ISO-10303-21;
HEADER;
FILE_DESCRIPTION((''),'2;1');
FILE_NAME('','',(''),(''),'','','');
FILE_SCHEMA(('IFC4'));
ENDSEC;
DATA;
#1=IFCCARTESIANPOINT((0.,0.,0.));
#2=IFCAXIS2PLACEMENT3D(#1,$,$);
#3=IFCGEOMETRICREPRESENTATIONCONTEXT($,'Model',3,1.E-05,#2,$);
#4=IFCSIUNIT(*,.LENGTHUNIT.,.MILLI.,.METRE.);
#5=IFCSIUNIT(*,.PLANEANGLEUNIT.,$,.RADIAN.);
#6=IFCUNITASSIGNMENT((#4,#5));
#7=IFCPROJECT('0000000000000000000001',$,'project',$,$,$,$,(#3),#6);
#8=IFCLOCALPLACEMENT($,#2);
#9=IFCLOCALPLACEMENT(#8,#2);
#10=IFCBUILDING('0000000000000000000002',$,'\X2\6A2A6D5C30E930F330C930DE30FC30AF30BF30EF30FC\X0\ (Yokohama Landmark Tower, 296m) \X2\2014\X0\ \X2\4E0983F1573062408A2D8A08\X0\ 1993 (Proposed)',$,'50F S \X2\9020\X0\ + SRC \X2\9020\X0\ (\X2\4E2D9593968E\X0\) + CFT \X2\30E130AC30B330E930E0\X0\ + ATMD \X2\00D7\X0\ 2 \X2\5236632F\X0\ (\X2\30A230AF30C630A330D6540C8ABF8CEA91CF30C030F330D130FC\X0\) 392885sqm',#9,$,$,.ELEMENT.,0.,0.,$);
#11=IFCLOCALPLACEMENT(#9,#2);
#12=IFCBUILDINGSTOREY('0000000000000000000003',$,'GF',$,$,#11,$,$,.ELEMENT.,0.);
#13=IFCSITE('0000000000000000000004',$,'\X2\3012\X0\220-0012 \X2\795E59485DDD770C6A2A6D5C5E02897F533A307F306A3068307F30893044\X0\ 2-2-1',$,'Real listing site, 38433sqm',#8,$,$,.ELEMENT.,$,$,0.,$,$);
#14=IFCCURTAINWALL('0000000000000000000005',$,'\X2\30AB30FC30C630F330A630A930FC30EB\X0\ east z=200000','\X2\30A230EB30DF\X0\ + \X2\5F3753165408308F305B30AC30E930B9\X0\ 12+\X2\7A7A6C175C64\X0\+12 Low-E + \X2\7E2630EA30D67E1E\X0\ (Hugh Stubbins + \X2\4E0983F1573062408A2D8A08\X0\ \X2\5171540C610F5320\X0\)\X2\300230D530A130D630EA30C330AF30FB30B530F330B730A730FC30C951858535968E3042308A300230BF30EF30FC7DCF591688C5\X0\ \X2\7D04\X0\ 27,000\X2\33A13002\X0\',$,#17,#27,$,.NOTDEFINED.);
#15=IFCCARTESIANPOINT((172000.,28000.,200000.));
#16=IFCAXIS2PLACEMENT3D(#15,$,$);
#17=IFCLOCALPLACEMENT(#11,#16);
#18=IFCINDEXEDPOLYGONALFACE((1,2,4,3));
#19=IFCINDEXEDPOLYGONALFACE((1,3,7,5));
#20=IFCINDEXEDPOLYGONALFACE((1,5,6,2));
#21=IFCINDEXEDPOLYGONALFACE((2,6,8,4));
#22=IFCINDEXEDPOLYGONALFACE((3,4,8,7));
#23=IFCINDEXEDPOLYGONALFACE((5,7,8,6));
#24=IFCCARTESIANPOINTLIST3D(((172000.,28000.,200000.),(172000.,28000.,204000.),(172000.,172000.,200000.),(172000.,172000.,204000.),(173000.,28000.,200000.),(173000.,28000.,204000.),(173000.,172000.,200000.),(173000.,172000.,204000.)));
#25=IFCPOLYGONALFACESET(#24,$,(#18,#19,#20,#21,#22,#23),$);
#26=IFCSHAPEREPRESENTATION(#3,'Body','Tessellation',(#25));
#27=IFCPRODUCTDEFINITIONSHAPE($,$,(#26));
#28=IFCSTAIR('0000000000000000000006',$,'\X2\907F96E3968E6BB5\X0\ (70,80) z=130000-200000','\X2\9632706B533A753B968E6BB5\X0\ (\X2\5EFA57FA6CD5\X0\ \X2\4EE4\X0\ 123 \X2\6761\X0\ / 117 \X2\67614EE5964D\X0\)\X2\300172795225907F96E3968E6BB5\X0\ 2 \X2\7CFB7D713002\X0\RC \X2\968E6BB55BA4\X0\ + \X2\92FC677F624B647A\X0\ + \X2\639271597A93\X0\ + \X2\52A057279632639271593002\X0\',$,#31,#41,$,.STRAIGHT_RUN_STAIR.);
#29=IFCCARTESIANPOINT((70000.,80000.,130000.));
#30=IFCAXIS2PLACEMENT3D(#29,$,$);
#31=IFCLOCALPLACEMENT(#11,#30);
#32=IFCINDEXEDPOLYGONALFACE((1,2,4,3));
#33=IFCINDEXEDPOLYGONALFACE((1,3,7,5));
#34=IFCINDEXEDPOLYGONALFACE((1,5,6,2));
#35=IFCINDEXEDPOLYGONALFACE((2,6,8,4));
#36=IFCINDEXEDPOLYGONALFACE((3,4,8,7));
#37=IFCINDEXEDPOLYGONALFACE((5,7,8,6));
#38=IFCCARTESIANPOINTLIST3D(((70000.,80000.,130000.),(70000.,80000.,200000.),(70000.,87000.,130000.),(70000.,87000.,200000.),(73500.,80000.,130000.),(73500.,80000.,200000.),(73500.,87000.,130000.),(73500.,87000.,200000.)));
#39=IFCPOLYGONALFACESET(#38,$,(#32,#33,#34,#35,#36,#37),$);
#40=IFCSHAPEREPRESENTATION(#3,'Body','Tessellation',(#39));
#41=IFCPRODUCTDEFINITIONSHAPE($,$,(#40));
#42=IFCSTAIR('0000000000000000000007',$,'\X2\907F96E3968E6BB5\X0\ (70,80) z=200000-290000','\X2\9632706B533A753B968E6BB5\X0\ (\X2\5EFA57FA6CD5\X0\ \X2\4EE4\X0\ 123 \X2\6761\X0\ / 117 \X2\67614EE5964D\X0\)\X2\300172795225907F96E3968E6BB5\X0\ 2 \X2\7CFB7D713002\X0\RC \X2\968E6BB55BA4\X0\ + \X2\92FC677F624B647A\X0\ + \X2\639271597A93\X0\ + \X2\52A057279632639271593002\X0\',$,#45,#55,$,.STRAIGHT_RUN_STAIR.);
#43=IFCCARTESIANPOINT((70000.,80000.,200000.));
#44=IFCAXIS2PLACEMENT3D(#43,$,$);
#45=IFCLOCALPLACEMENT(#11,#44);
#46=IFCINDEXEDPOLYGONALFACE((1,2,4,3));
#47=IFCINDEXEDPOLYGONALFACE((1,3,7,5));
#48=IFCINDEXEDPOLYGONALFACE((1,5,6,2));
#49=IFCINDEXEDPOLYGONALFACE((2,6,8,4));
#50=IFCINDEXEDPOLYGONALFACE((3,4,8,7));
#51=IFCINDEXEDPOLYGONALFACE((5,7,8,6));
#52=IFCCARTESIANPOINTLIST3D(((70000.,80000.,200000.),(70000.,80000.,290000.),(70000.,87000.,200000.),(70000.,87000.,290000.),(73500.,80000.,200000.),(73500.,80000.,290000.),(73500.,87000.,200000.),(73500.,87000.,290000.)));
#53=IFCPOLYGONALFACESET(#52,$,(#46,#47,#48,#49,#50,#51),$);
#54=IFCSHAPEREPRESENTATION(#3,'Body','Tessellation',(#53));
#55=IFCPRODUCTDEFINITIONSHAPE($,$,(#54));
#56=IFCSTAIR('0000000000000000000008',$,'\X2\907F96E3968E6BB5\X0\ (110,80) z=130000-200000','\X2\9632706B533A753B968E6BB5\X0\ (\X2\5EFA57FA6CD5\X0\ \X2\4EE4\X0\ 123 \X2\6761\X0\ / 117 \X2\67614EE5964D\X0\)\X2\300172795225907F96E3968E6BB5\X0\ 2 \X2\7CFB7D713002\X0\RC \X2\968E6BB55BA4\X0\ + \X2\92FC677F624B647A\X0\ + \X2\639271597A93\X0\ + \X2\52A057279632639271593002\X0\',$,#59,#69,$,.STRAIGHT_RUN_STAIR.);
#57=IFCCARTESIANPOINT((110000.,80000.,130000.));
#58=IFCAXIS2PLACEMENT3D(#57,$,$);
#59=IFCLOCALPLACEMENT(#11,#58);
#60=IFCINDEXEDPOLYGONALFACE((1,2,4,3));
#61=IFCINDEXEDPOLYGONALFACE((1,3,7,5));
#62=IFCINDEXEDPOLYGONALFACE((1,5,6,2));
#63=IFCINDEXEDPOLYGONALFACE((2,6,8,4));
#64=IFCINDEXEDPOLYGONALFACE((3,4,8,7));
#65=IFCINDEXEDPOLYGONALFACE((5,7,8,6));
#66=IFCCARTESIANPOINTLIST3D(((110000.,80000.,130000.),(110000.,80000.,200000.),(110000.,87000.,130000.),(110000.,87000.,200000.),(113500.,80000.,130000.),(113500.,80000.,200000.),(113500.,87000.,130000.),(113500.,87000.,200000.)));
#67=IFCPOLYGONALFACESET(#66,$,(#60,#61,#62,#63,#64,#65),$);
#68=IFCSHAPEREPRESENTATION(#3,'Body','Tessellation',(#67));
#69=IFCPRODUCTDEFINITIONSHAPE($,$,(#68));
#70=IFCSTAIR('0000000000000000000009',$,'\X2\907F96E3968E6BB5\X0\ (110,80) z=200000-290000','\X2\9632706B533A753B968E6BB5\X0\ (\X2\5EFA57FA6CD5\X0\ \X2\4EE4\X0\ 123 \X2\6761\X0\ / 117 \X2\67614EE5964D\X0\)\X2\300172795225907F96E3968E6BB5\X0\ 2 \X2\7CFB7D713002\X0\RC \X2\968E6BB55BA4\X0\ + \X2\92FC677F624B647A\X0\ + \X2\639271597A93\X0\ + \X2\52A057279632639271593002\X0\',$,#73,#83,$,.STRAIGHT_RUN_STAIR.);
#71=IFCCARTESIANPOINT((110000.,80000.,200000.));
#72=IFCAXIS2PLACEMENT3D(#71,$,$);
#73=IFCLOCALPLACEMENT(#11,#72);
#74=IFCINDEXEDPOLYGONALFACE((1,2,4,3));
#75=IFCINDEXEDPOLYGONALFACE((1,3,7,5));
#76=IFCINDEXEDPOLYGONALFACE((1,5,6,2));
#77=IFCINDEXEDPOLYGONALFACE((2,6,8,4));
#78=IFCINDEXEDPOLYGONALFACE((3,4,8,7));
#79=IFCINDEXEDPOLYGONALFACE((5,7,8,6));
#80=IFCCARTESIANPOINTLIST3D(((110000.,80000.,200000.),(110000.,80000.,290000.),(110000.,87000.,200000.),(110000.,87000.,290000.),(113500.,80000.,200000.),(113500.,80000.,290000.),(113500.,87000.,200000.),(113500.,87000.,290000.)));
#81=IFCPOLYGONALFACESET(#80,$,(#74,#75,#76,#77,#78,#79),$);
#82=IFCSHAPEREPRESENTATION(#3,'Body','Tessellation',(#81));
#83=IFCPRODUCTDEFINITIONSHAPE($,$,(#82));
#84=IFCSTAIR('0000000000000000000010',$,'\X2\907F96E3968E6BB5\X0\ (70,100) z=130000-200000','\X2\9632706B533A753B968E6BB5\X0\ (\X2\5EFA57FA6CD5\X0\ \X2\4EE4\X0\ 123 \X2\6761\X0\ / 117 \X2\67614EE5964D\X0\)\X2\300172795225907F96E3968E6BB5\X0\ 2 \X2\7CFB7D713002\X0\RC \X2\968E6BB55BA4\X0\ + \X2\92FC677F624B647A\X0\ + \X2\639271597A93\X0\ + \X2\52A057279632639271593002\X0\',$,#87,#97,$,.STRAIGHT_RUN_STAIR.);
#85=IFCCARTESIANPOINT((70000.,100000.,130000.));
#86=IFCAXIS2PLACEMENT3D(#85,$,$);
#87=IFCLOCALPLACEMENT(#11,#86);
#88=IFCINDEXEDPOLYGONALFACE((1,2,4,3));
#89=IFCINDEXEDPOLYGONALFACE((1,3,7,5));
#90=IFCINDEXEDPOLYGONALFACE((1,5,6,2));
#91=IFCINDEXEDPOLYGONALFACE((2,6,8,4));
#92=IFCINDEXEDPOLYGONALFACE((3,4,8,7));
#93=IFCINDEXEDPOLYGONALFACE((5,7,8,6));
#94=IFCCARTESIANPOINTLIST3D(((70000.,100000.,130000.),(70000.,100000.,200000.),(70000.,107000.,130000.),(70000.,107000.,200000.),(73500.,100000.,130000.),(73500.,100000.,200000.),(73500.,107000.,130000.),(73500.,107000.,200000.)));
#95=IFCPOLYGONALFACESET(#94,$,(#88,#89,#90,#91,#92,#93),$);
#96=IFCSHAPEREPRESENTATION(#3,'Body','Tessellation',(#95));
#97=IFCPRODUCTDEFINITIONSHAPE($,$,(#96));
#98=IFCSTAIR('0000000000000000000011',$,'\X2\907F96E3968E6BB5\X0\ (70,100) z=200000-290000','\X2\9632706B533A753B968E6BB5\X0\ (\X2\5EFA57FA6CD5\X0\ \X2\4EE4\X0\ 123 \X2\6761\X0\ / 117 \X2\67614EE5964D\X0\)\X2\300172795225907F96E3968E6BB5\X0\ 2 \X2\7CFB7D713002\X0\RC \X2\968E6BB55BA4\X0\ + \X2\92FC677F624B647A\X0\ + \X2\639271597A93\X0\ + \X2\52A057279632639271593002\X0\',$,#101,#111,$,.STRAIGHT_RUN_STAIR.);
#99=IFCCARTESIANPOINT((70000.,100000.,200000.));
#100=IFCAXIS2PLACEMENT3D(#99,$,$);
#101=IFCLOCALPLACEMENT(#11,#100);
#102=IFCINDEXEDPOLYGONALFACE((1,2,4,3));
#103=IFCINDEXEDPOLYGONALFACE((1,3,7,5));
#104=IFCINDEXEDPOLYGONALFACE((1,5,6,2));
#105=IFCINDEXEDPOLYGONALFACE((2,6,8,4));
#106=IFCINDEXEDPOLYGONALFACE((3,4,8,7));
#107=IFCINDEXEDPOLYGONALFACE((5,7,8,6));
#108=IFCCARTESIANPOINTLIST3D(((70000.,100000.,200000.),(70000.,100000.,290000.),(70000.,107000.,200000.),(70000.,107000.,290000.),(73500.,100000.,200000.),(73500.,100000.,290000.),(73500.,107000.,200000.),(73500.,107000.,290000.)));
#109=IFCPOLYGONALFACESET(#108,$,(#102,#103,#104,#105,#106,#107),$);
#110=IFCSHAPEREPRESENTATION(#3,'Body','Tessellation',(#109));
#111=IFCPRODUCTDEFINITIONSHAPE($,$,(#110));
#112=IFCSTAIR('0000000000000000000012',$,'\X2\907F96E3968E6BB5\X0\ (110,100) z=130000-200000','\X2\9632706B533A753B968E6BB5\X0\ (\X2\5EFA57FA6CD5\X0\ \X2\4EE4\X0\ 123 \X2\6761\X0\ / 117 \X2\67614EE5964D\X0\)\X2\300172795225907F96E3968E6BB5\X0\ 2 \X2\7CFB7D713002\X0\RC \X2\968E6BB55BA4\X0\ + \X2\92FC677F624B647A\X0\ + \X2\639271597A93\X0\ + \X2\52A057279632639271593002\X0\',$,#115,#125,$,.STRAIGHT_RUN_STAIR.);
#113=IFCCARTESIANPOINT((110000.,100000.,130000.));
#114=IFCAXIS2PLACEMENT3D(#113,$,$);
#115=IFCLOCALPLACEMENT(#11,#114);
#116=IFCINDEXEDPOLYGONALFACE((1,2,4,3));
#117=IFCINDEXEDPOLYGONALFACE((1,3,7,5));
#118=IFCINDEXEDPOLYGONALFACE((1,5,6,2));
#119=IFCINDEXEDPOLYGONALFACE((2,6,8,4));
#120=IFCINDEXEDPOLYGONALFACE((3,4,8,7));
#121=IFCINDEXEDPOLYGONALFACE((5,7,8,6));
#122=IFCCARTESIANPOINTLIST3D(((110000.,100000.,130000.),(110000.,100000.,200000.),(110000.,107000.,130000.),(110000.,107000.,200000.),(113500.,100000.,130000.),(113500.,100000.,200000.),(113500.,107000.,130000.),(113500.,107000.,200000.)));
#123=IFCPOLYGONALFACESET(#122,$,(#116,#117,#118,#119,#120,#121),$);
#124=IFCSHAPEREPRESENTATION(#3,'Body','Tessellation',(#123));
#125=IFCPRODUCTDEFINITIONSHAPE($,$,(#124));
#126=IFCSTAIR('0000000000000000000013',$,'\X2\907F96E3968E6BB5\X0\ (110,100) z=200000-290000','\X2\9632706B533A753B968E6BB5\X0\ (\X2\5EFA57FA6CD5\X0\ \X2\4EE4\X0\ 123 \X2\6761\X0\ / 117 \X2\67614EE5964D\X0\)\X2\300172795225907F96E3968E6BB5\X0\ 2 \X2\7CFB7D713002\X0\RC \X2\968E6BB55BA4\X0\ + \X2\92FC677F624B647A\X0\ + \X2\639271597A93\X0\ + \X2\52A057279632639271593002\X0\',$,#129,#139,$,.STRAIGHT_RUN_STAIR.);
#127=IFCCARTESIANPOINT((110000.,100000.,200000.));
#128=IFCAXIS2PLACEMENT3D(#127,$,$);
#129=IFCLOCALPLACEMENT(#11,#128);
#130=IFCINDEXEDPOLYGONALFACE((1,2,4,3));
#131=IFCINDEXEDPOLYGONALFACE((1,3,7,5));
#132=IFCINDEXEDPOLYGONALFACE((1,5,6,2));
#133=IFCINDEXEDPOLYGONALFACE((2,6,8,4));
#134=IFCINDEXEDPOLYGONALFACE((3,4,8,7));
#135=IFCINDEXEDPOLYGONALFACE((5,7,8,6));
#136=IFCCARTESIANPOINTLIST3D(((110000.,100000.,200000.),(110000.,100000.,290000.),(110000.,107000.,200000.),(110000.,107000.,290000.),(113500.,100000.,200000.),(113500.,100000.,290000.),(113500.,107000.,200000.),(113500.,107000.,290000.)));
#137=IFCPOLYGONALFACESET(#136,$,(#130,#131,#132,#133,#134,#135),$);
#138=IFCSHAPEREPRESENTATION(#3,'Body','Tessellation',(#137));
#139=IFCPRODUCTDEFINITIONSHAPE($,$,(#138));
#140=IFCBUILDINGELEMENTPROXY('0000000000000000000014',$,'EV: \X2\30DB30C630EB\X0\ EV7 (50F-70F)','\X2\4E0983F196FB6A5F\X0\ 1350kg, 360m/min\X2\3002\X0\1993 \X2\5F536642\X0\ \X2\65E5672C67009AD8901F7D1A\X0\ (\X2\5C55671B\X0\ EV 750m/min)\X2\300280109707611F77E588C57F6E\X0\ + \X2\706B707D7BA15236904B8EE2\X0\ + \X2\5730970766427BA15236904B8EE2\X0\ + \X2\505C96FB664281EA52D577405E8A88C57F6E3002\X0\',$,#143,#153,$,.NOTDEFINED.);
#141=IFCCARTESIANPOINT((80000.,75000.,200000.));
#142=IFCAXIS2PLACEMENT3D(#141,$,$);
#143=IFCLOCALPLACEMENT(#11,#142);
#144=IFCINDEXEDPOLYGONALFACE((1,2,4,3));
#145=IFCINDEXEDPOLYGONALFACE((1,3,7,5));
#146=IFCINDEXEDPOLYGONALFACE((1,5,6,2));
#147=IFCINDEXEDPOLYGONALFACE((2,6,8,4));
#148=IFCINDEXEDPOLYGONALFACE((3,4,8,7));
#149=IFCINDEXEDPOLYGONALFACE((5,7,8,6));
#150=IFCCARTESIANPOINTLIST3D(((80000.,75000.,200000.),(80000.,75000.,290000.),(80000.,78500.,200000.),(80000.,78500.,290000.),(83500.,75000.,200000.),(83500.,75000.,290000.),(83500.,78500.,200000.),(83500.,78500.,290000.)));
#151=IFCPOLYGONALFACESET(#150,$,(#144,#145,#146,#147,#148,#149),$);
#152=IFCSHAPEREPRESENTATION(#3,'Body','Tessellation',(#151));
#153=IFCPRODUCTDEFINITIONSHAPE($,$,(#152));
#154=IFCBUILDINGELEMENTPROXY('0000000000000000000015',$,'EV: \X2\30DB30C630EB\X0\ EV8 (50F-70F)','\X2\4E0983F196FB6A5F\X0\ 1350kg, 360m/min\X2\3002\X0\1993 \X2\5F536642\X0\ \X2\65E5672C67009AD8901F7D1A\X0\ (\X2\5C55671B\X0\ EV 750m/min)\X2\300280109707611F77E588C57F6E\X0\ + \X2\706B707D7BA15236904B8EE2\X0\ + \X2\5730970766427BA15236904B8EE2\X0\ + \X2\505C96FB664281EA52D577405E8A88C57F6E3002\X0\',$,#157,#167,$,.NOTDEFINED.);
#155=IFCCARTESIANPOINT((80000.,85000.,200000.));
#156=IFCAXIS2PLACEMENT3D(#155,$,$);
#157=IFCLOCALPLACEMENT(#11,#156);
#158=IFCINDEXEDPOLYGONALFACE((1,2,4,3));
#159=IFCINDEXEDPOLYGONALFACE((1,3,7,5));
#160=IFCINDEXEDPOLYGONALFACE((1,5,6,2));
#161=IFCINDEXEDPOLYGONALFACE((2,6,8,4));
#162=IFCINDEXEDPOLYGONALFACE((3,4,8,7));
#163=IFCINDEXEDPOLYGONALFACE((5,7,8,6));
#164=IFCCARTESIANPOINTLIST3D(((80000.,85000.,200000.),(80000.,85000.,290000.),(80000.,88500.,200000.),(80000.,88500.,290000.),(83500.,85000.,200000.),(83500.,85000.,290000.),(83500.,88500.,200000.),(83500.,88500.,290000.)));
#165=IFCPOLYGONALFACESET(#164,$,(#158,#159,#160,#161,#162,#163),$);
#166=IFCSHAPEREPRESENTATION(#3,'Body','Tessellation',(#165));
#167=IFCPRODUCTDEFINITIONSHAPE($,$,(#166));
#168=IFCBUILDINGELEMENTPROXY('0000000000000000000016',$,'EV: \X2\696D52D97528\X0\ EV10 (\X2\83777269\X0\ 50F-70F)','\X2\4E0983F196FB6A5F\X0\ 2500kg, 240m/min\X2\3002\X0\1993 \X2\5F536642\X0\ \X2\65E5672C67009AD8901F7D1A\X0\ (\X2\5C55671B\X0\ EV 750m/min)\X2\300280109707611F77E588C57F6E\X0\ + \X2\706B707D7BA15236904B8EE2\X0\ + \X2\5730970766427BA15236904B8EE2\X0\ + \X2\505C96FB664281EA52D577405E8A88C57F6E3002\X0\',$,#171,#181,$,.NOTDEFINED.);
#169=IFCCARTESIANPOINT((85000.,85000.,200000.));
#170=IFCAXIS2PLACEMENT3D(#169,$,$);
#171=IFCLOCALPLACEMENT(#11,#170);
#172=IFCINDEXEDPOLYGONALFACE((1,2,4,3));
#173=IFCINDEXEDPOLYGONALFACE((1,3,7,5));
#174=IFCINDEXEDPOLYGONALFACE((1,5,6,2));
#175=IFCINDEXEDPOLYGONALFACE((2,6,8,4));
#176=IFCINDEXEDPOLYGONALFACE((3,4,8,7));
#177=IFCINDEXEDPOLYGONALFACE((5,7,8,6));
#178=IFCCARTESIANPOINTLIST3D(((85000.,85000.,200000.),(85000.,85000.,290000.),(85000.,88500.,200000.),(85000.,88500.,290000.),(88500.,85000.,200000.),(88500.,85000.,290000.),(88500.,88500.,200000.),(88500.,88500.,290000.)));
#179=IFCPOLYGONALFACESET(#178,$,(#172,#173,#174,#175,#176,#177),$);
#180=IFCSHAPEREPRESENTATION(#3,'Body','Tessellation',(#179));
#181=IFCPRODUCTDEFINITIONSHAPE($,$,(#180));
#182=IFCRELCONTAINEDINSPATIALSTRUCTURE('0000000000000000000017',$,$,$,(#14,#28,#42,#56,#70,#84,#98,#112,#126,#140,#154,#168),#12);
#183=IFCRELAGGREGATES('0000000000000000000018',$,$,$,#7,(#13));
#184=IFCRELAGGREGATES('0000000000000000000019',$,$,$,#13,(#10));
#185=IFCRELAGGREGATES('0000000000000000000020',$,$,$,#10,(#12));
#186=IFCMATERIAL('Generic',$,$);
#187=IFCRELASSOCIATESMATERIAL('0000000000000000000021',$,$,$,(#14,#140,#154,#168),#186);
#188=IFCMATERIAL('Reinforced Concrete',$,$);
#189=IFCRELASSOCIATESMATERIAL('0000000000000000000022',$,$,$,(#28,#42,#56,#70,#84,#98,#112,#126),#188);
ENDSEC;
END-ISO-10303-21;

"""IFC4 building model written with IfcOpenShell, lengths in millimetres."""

from ifc_helpers import new_model, si_unit, frame, frame_2d, origin, place, context, project, spatial, rectangle, extrude, material, element, save


model = new_model("IFC4")

# Units and contexts
model_context = context("Model", 3, precision=1e-05, world=origin())
ifc_project = project(units=[si_unit("LENGTHUNIT", "METRE", prefix="MILLI"), si_unit("PLANEANGLEUNIT", "RADIAN")], contexts=[model_context])

# Site, building, storey
site_placement = place(None, origin())
site = spatial("IfcSite", under=ifc_project, at=site_placement, Name="〒220-0012 神奈川県横浜市西区みなとみらい 2-2-1", ObjectType="Real listing site, 38433sqm", CompositionType="ELEMENT", RefElevation=0.0)
building_placement = place(site_placement, origin())
building = spatial("IfcBuilding", under=site, at=building_placement, Name="横浜ランドマークタワー (Yokohama Landmark Tower, 296m) — 三菱地所設計 1993 (Proposed)", ObjectType="50F S 造 + SRC 造 (中間階) + CFT メガコラム + ATMD × 2 制振 (アクティブ同調質量ダンパー) 392885sqm", CompositionType="ELEMENT", ElevationOfRefHeight=0.0, ElevationOfTerrain=0.0)
storey_placement = place(building_placement, origin())
storey = spatial("IfcBuildingStorey", under=building, at=storey_placement, Name="GF", CompositionType="ELEMENT", Elevation=0.0)

# Shared definitions
ifc_material_1 = material(Name="Reinforced Concrete")

# Shared definitions
ifc_material_2 = material(Name="Generic")

# Curtain wall
curtain_wall_1_placement = place(storey_placement, frame((172000.0, 28000.0, 200000.0)))
element("IfcCurtainWall", 1, at=curtain_wall_1_placement, inside=storey, material=ifc_material_2, Name="カーテンウォール east z=200000", Description="アルミ + 強化合わせガラス 12+空気層+12 Low-E + 縦リブ縞 (Hugh Stubbins + 三菱地所設計 共同意匠)。ファブリック・サンシェード内蔵階あり。タワー総外装 約 27,000㎡。", PredefinedType="NOTDEFINED", context=model_context, shape_type="SweptSolid", body=[
    extrude(rectangle(XDim=1000.0, YDim=144000.0, at=frame_2d((500.0, 72000.0))), frame((172000.0, 28000.0, 200000.0)), (0.0, 0.0, 1.0), 4000.0),
])

# Stairs
stair_1_placement = place(storey_placement, frame((70000.0, 80000.0, 130000.0)))
element("IfcStair", 2, at=stair_1_placement, inside=storey, material=ifc_material_1, Name="避難階段 (70,80) z=130000-200000", Description="防火区画階段 (建基法 令 123 条 / 117 条以降)、特別避難階段 2 系統。RC 階段室 + 鋼板手摺 + 排煙窓 + 加圧防排煙。", PredefinedType="STRAIGHT_RUN_STAIR", context=model_context, shape_type="SweptSolid", body=[
    extrude(rectangle(XDim=3500.0, YDim=7000.0, at=frame_2d((1750.0, 3500.0))), frame((70000.0, 80000.0, 130000.0)), (0.0, 0.0, 1.0), 70000.0),
])
stair_2_placement = place(storey_placement, frame((70000.0, 80000.0, 200000.0)))
element("IfcStair", 3, at=stair_2_placement, inside=storey, material=ifc_material_1, Name="避難階段 (70,80) z=200000-290000", Description="防火区画階段 (建基法 令 123 条 / 117 条以降)、特別避難階段 2 系統。RC 階段室 + 鋼板手摺 + 排煙窓 + 加圧防排煙。", PredefinedType="STRAIGHT_RUN_STAIR", context=model_context, shape_type="SweptSolid", body=[
    extrude(rectangle(XDim=3500.0, YDim=7000.0, at=frame_2d((1750.0, 3500.0))), frame((70000.0, 80000.0, 200000.0)), (0.0, 0.0, 1.0), 90000.0),
])
stair_3_placement = place(storey_placement, frame((110000.0, 80000.0, 130000.0)))
element("IfcStair", 4, at=stair_3_placement, inside=storey, material=ifc_material_1, Name="避難階段 (110,80) z=130000-200000", Description="防火区画階段 (建基法 令 123 条 / 117 条以降)、特別避難階段 2 系統。RC 階段室 + 鋼板手摺 + 排煙窓 + 加圧防排煙。", PredefinedType="STRAIGHT_RUN_STAIR", context=model_context, shape_type="SweptSolid", body=[
    extrude(rectangle(XDim=3500.0, YDim=7000.0, at=frame_2d((1750.0, 3500.0))), frame((110000.0, 80000.0, 130000.0)), (0.0, 0.0, 1.0), 70000.0),
])
stair_4_placement = place(storey_placement, frame((110000.0, 80000.0, 200000.0)))
element("IfcStair", 5, at=stair_4_placement, inside=storey, material=ifc_material_1, Name="避難階段 (110,80) z=200000-290000", Description="防火区画階段 (建基法 令 123 条 / 117 条以降)、特別避難階段 2 系統。RC 階段室 + 鋼板手摺 + 排煙窓 + 加圧防排煙。", PredefinedType="STRAIGHT_RUN_STAIR", context=model_context, shape_type="SweptSolid", body=[
    extrude(rectangle(XDim=3500.0, YDim=7000.0, at=frame_2d((1750.0, 3500.0))), frame((110000.0, 80000.0, 200000.0)), (0.0, 0.0, 1.0), 90000.0),
])
stair_5_placement = place(storey_placement, frame((70000.0, 100000.0, 130000.0)))
element("IfcStair", 6, at=stair_5_placement, inside=storey, material=ifc_material_1, Name="避難階段 (70,100) z=130000-200000", Description="防火区画階段 (建基法 令 123 条 / 117 条以降)、特別避難階段 2 系統。RC 階段室 + 鋼板手摺 + 排煙窓 + 加圧防排煙。", PredefinedType="STRAIGHT_RUN_STAIR", context=model_context, shape_type="SweptSolid", body=[
    extrude(rectangle(XDim=3500.0, YDim=7000.0, at=frame_2d((1750.0, 3500.0))), frame((70000.0, 100000.0, 130000.0)), (0.0, 0.0, 1.0), 70000.0),
])
stair_6_placement = place(storey_placement, frame((70000.0, 100000.0, 200000.0)))
element("IfcStair", 7, at=stair_6_placement, inside=storey, material=ifc_material_1, Name="避難階段 (70,100) z=200000-290000", Description="防火区画階段 (建基法 令 123 条 / 117 条以降)、特別避難階段 2 系統。RC 階段室 + 鋼板手摺 + 排煙窓 + 加圧防排煙。", PredefinedType="STRAIGHT_RUN_STAIR", context=model_context, shape_type="SweptSolid", body=[
    extrude(rectangle(XDim=3500.0, YDim=7000.0, at=frame_2d((1750.0, 3500.0))), frame((70000.0, 100000.0, 200000.0)), (0.0, 0.0, 1.0), 90000.0),
])
stair_7_placement = place(storey_placement, frame((110000.0, 100000.0, 130000.0)))
element("IfcStair", 8, at=stair_7_placement, inside=storey, material=ifc_material_1, Name="避難階段 (110,100) z=130000-200000", Description="防火区画階段 (建基法 令 123 条 / 117 条以降)、特別避難階段 2 系統。RC 階段室 + 鋼板手摺 + 排煙窓 + 加圧防排煙。", PredefinedType="STRAIGHT_RUN_STAIR", context=model_context, shape_type="SweptSolid", body=[
    extrude(rectangle(XDim=3500.0, YDim=7000.0, at=frame_2d((1750.0, 3500.0))), frame((110000.0, 100000.0, 130000.0)), (0.0, 0.0, 1.0), 70000.0),
])
stair_8_placement = place(storey_placement, frame((110000.0, 100000.0, 200000.0)))
element("IfcStair", 9, at=stair_8_placement, inside=storey, material=ifc_material_1, Name="避難階段 (110,100) z=200000-290000", Description="防火区画階段 (建基法 令 123 条 / 117 条以降)、特別避難階段 2 系統。RC 階段室 + 鋼板手摺 + 排煙窓 + 加圧防排煙。", PredefinedType="STRAIGHT_RUN_STAIR", context=model_context, shape_type="SweptSolid", body=[
    extrude(rectangle(XDim=3500.0, YDim=7000.0, at=frame_2d((1750.0, 3500.0))), frame((110000.0, 100000.0, 200000.0)), (0.0, 0.0, 1.0), 90000.0),
])

# Building element proxies
proxy_1_placement = place(storey_placement, frame((80000.0, 75000.0, 200000.0)))
element("IfcBuildingElementProxy", 10, at=proxy_1_placement, inside=storey, material=ifc_material_2, Name="EV: ホテル EV7 (50F-70F)", Description="三菱電機 1350kg, 360m/min。1993 当時 日本最高速級 (展望 EV 750m/min)。耐震感知装置 + 火災管制運転 + 地震時管制運転 + 停電時自動着床装置。", PredefinedType="NOTDEFINED", context=model_context, shape_type="SweptSolid", body=[
    extrude(rectangle(XDim=3500.0, YDim=3500.0, at=frame_2d((1750.0, 1750.0))), frame((80000.0, 75000.0, 200000.0)), (0.0, 0.0, 1.0), 90000.0),
])
proxy_2_placement = place(storey_placement, frame((80000.0, 85000.0, 200000.0)))
element("IfcBuildingElementProxy", 11, at=proxy_2_placement, inside=storey, material=ifc_material_2, Name="EV: ホテル EV8 (50F-70F)", Description="三菱電機 1350kg, 360m/min。1993 当時 日本最高速級 (展望 EV 750m/min)。耐震感知装置 + 火災管制運転 + 地震時管制運転 + 停電時自動着床装置。", PredefinedType="NOTDEFINED", context=model_context, shape_type="SweptSolid", body=[
    extrude(rectangle(XDim=3500.0, YDim=3500.0, at=frame_2d((1750.0, 1750.0))), frame((80000.0, 85000.0, 200000.0)), (0.0, 0.0, 1.0), 90000.0),
])
proxy_3_placement = place(storey_placement, frame((85000.0, 85000.0, 200000.0)))
element("IfcBuildingElementProxy", 12, at=proxy_3_placement, inside=storey, material=ifc_material_2, Name="EV: 業務用 EV10 (荷物 50F-70F)", Description="三菱電機 2500kg, 240m/min。1993 当時 日本最高速級 (展望 EV 750m/min)。耐震感知装置 + 火災管制運転 + 地震時管制運転 + 停電時自動着床装置。", PredefinedType="NOTDEFINED", context=model_context, shape_type="SweptSolid", body=[
    extrude(rectangle(XDim=3500.0, YDim=3500.0, at=frame_2d((1750.0, 1750.0))), frame((85000.0, 85000.0, 200000.0)), (0.0, 0.0, 1.0), 90000.0),
])

save(model, "model.ifc")
